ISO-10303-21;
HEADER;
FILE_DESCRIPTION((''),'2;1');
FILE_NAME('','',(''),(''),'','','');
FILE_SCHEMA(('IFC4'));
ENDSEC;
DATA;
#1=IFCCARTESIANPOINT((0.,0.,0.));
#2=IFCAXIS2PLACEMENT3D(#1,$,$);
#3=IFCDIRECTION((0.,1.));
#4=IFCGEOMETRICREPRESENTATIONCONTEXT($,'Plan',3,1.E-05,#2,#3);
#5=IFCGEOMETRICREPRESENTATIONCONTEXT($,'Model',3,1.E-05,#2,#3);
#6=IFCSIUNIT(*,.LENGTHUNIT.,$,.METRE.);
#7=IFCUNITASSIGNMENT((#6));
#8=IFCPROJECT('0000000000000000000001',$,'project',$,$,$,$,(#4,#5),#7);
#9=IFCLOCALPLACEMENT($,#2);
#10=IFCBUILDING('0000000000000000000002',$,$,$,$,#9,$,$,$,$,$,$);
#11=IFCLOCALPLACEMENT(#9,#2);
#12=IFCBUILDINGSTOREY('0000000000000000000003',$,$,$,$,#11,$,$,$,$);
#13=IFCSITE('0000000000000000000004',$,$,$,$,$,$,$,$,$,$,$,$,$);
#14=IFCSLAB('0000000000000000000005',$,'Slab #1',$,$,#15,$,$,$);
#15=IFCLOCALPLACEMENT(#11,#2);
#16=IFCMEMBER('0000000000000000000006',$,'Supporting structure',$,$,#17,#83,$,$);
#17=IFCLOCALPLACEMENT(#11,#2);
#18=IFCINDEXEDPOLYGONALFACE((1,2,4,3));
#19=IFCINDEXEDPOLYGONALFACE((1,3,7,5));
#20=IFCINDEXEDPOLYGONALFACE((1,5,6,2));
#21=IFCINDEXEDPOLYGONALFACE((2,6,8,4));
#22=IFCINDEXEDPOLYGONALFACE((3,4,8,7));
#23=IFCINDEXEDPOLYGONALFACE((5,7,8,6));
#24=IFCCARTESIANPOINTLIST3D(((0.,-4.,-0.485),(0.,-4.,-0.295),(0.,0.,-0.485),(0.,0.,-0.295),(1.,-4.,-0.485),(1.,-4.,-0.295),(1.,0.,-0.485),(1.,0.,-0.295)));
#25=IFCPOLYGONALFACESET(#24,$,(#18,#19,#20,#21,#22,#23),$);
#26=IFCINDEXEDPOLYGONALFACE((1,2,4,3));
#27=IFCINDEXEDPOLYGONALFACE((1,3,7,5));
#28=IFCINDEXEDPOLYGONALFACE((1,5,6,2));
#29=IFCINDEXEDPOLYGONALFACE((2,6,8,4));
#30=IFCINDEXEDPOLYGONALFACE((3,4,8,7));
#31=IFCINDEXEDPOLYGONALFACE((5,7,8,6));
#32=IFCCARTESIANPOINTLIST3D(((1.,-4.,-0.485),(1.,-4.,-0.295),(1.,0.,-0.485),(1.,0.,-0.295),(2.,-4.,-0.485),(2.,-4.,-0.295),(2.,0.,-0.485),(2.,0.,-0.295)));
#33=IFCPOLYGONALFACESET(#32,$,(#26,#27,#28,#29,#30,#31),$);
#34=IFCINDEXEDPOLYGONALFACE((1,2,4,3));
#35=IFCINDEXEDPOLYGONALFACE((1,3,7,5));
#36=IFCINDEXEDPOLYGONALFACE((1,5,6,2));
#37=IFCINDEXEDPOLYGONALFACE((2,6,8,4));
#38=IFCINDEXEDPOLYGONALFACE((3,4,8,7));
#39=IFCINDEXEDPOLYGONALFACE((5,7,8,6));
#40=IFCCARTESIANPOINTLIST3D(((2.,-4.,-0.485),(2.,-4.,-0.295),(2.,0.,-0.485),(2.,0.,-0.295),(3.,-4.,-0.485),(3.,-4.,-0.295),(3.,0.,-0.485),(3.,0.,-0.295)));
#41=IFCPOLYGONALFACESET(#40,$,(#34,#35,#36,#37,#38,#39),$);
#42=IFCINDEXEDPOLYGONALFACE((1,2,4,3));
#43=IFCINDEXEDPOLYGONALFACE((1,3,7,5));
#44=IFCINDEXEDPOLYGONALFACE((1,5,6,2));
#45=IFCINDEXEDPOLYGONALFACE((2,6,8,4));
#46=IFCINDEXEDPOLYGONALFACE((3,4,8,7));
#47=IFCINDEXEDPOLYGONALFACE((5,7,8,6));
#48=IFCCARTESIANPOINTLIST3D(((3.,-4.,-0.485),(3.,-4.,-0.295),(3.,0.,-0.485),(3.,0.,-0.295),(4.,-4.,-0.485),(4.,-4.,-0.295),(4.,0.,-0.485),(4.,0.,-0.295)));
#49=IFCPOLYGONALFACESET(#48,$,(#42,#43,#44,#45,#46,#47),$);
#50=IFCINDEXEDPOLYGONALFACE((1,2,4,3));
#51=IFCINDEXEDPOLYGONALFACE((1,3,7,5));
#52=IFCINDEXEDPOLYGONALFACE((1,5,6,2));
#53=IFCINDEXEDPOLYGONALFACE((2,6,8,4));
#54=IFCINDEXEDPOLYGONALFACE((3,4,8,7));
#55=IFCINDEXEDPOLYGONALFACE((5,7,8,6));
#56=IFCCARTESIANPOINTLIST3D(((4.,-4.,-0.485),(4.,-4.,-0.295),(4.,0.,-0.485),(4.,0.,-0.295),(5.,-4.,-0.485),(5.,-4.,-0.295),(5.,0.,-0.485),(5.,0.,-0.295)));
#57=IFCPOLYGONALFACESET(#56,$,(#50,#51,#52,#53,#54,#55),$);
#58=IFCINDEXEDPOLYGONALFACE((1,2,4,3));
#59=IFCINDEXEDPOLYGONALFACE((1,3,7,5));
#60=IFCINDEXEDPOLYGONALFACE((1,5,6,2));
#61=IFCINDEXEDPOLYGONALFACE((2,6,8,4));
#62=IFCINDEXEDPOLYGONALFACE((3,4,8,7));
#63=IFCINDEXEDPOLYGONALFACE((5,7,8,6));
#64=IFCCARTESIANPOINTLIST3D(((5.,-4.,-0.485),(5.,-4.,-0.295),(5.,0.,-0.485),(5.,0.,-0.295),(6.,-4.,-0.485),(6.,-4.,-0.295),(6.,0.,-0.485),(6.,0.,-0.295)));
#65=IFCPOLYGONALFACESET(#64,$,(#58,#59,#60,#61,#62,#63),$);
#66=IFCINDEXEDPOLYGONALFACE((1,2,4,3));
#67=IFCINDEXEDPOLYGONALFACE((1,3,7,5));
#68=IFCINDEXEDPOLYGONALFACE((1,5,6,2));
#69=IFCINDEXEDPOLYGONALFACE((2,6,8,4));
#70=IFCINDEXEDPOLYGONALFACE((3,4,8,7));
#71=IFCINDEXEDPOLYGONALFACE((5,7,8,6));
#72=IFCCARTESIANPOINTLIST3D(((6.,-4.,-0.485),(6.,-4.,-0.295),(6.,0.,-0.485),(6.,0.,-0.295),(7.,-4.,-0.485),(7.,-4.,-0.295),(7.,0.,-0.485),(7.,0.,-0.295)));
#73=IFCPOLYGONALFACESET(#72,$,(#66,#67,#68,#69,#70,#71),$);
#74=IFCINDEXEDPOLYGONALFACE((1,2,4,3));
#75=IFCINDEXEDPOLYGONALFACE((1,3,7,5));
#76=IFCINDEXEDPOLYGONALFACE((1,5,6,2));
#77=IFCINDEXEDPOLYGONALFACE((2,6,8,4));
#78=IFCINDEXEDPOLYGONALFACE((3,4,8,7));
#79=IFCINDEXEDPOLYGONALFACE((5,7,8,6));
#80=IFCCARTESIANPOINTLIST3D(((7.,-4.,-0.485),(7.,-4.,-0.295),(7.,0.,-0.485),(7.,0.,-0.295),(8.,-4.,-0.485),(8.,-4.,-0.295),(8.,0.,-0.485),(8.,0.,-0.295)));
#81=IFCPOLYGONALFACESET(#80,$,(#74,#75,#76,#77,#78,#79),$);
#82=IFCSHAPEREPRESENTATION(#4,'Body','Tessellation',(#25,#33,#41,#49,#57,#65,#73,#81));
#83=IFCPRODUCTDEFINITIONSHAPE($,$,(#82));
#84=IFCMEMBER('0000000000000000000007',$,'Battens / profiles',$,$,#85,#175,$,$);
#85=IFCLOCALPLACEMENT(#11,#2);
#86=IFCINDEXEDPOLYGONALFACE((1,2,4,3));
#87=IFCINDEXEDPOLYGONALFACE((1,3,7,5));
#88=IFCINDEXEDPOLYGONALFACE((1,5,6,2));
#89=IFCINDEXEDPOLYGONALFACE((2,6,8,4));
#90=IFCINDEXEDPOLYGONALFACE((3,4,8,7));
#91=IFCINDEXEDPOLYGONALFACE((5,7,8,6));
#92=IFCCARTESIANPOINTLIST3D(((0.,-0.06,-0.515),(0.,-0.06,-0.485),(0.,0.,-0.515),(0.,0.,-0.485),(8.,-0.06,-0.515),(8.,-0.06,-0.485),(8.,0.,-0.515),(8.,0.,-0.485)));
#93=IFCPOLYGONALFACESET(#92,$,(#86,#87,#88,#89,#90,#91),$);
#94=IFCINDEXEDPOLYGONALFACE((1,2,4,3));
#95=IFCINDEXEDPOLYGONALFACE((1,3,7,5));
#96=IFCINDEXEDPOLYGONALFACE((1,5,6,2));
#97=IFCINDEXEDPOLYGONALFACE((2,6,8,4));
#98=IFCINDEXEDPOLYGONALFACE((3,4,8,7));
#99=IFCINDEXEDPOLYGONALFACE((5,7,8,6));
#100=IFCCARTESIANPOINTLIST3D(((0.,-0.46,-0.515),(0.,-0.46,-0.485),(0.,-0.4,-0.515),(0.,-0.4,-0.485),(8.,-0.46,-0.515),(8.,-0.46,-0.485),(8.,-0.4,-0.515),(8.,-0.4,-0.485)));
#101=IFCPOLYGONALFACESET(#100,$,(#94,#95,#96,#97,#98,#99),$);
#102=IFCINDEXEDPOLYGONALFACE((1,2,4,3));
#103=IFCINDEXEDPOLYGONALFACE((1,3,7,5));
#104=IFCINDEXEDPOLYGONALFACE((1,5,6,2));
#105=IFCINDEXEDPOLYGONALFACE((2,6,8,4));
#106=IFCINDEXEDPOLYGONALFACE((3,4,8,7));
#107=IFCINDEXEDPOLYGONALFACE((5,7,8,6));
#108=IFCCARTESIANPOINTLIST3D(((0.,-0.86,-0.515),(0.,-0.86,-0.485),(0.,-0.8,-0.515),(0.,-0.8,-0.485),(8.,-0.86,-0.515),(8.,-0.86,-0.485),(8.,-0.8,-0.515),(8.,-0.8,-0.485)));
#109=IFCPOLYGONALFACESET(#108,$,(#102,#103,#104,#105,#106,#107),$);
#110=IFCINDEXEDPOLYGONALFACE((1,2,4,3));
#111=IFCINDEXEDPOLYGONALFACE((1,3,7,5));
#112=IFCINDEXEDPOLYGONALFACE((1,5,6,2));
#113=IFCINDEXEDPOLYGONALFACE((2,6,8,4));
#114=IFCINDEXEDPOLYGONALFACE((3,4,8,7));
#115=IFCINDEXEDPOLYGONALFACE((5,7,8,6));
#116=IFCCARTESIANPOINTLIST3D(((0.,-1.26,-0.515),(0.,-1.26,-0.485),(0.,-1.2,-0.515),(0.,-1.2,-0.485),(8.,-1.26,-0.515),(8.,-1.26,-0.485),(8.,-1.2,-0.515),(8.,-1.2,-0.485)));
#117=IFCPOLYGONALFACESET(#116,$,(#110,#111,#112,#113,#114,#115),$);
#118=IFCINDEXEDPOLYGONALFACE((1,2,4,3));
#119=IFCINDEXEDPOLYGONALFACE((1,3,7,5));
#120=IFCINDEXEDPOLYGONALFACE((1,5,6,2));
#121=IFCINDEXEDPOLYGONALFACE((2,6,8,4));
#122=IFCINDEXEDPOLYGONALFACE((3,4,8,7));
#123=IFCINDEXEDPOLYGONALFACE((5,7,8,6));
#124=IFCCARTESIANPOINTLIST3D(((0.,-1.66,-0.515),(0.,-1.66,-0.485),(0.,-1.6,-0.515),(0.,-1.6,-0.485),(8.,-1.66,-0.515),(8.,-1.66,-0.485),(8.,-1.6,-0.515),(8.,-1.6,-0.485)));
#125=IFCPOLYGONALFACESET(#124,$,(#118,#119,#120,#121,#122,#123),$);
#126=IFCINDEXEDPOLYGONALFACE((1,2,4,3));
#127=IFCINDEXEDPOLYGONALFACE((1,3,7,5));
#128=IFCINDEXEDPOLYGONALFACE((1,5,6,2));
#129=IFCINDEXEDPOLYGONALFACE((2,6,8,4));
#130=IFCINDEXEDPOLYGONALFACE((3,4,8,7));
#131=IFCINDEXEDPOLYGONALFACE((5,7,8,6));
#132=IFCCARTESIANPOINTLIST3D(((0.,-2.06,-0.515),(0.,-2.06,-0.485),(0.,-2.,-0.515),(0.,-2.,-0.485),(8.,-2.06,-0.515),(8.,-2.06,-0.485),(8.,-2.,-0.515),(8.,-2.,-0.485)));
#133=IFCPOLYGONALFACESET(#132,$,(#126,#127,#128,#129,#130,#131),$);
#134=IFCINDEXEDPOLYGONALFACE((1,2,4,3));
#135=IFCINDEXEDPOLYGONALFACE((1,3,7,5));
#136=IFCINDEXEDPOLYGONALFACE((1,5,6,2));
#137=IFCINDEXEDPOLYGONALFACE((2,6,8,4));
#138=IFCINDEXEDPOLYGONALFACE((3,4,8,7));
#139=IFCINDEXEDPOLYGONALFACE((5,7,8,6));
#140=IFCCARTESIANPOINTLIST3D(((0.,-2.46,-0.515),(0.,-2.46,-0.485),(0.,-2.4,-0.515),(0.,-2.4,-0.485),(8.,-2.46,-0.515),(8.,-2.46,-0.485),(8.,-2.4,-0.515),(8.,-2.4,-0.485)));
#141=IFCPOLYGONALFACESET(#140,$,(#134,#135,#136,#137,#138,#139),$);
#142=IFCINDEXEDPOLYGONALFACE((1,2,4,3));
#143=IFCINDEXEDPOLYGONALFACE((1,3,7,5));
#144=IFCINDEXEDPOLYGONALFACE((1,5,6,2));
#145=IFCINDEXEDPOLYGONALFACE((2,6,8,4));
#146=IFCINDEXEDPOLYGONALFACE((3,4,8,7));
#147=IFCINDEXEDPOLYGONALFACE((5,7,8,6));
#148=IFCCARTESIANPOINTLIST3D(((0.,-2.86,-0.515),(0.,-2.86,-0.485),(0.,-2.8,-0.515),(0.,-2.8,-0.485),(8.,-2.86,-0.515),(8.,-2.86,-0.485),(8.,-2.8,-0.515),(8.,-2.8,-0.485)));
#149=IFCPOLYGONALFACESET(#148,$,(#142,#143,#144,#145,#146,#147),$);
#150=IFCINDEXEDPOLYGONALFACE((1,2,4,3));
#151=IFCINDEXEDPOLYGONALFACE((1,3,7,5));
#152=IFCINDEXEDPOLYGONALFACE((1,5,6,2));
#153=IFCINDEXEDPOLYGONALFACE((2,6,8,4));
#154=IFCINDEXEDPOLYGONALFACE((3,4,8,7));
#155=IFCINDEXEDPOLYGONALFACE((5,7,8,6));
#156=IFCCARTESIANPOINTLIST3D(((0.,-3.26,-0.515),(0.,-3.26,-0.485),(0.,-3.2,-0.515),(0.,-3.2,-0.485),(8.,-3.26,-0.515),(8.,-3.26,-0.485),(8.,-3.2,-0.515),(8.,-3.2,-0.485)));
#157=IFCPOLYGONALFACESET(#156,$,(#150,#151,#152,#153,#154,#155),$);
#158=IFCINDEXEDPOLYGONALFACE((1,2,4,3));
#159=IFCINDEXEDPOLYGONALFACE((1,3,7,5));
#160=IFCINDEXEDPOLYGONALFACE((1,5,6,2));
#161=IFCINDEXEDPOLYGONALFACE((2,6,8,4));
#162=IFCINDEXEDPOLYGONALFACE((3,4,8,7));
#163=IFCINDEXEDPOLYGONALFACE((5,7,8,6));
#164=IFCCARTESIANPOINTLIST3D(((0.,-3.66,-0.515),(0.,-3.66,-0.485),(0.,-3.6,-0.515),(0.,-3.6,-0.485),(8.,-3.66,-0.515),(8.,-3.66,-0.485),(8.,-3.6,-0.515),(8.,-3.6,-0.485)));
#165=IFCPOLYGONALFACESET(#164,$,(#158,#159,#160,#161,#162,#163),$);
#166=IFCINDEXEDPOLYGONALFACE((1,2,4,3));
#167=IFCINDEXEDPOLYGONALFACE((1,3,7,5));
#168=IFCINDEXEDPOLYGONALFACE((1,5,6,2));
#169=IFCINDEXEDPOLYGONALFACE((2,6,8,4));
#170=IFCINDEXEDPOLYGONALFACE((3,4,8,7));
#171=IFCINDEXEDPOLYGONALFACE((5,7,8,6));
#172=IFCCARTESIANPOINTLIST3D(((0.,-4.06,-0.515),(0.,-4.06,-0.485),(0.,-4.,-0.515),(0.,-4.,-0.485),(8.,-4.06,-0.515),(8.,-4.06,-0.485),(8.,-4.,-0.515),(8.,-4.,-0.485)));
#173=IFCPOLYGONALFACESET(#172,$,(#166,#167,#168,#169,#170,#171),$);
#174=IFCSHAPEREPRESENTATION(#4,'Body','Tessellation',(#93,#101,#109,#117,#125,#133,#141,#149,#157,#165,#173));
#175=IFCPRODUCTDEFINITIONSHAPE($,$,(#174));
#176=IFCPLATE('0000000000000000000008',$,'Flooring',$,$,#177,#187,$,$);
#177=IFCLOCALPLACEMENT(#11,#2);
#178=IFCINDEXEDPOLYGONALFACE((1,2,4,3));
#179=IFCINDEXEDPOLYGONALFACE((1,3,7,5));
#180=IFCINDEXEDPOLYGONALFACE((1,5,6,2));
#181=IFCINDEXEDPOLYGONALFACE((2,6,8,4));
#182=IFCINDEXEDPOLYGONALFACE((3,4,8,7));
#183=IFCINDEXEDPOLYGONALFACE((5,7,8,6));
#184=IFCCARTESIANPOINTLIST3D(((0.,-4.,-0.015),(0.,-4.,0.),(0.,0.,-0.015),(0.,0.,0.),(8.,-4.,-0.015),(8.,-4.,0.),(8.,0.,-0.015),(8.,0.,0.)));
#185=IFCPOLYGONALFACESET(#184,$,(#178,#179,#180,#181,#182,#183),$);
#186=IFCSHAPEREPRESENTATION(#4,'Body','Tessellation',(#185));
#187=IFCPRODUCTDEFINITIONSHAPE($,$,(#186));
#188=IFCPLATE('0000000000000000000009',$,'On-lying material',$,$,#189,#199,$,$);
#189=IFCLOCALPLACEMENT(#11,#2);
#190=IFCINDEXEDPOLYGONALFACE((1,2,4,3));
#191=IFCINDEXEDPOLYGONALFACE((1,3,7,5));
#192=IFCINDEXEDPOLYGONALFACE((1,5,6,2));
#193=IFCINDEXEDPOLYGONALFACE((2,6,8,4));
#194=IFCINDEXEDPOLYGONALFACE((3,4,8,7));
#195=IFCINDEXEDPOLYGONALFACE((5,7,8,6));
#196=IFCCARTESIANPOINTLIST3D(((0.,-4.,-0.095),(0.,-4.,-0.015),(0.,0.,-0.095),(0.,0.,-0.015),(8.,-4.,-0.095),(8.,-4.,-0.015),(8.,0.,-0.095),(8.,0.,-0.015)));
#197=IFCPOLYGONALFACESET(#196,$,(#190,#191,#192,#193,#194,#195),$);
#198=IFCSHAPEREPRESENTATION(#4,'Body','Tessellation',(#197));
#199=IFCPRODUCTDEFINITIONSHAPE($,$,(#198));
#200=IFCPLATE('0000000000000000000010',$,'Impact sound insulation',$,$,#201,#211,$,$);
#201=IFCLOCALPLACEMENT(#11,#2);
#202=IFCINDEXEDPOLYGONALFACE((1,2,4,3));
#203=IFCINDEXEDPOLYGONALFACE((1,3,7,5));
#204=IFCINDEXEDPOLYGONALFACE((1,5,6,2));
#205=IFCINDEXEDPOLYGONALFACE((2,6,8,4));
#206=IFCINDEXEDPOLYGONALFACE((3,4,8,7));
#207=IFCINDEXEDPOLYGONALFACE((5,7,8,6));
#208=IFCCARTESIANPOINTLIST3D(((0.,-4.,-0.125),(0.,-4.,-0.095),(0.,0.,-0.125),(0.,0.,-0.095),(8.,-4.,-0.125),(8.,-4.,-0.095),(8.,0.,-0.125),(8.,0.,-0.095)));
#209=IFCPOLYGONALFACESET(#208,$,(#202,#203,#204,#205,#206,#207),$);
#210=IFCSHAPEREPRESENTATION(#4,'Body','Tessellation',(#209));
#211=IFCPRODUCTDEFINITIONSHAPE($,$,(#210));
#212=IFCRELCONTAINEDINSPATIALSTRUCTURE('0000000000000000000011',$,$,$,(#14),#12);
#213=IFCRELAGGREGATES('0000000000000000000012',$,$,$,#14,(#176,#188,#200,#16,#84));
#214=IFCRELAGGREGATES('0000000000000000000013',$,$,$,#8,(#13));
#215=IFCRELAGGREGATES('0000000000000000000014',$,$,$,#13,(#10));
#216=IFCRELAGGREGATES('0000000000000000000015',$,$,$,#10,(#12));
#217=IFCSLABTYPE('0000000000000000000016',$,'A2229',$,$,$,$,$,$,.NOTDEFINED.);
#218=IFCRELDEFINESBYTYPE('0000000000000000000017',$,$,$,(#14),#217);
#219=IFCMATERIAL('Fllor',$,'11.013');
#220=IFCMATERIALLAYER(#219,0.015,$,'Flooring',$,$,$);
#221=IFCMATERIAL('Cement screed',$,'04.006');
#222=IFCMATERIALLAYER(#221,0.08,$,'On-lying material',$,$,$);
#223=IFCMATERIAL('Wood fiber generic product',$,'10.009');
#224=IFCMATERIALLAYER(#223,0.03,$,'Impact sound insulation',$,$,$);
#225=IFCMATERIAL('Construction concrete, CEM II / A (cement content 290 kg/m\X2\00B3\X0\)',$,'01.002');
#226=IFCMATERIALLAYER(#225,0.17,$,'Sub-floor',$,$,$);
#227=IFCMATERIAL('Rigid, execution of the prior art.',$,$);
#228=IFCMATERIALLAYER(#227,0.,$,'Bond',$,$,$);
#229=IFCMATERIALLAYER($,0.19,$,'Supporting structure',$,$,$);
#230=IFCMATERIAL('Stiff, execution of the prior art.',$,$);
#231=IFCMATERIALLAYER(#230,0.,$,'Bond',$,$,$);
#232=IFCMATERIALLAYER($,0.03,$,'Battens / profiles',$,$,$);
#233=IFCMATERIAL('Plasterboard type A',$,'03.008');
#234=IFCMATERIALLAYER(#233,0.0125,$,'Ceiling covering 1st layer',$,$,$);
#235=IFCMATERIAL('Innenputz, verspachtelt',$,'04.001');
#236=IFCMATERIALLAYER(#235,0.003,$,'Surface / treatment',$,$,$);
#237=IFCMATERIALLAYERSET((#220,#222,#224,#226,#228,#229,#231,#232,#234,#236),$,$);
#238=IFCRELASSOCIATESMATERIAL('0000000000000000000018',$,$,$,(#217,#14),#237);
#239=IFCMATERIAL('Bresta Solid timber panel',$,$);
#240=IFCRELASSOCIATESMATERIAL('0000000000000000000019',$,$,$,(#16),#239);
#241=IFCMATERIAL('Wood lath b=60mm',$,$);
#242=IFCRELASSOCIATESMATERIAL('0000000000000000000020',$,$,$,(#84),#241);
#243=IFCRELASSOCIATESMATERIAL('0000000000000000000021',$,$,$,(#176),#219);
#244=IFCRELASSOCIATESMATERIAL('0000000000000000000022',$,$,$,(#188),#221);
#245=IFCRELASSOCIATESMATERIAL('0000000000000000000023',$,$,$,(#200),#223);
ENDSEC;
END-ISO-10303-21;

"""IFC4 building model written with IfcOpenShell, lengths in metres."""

from ifc_helpers import new_model, si_unit, direction, frame, frame_2d, origin, origin_with_axes, place, context, project, spatial, rectangle, extrude, material, layer, layer_set, type_object, element, aggregate, save


model = new_model("IFC4")

# Units and contexts
plan_context = context("Plan", 3, precision=1e-05, world=origin(), true_north=direction((0.0, 1.0)))
model_context = context("Model", 3, precision=1e-05, world=origin(), true_north=direction((0.0, 1.0)))
ifc_project = project(units=[si_unit("LENGTHUNIT", "METRE")], contexts=[plan_context, model_context])

# Site, building, storey
site = spatial("IfcSite", under=ifc_project)
building_placement = place(None, origin())
building = spatial("IfcBuilding", under=site, at=building_placement)
storey_placement = place(building_placement, origin())
storey = spatial("IfcBuildingStorey", under=building, at=storey_placement)

# Slab, members, plates
ifc_material_1 = material(Name="Fllor", Category="11.013")
ifc_layer_1 = layer(ifc_material_1, 0.015, Name="Flooring")
ifc_material_2 = material(Name="Cement screed", Category="04.006")
ifc_layer_2 = layer(ifc_material_2, 0.08, Name="On-lying material")
ifc_material_3 = material(Name="Wood fiber generic product", Category="10.009")
ifc_layer_3 = layer(ifc_material_3, 0.03, Name="Impact sound insulation")
ifc_material_4 = material(Name="Construction concrete, CEM II / A (cement content 290 kg/m³)", Category="01.002")
ifc_layer_4 = layer(ifc_material_4, 0.17, Name="Sub-floor")
ifc_material_5 = material(Name="Rigid, execution of the prior art.")
ifc_layer_5 = layer(ifc_material_5, 0.0, Name="Bond")
ifc_layer_6 = layer(None, 0.19, Name="Supporting structure")
ifc_material_6 = material(Name="Stiff, execution of the prior art.")
ifc_layer_7 = layer(ifc_material_6, 0.0, Name="Bond")
ifc_layer_8 = layer(None, 0.03, Name="Battens / profiles")
ifc_material_7 = material(Name="Plasterboard type A", Category="03.008")
ifc_layer_9 = layer(ifc_material_7, 0.0125, Name="Ceiling covering 1st layer")
ifc_material_8 = material(Name="Innenputz, verspachtelt", Category="04.001")
ifc_layer_10 = layer(ifc_material_8, 0.003, Name="Surface / treatment")
ifc_layer_set = layer_set([ifc_layer_1, ifc_layer_2, ifc_layer_3, ifc_layer_4, ifc_layer_5, ifc_layer_6, ifc_layer_7, ifc_layer_8, ifc_layer_9, ifc_layer_10])
slab_type = type_object("IfcSlabType", Name="A2229", PredefinedType="NOTDEFINED", material=ifc_layer_set)
slab_placement = place(None, frame((0.0, 0.0, 0.0), z_axis=(0.0, 0.0, -1.0), x_axis=(1.0, 0.0, 0.0)))
slab = element("IfcSlab", 1, at=slab_placement, inside=storey, type_object=slab_type, material=ifc_layer_set, Name="Slab #1")
ifc_material_9 = material(Name="Bresta Solid timber panel")
member_1_placement = place(slab_placement, origin())
member_1 = element("IfcMember", 2, at=member_1_placement, material=ifc_material_9, Name="Supporting structure", context=plan_context, shape_type="SweptSolid", body=[
    extrude(rectangle(XDim=1.0, YDim=0.19, at=frame_2d((0.5, 0.095), x_axis=(1.0, 0.0))), frame((0.0, 4.0, 0.295), z_axis=(0.0, -1.0, 0.0), x_axis=(1.0, 0.0, 0.0)), (0.0, 0.0, 1.0), 4.0),
    extrude(rectangle(XDim=1.0, YDim=0.19, at=frame_2d((0.5, 0.095), x_axis=(1.0, 0.0))), frame((1.0, 4.0, 0.295), z_axis=(0.0, -1.0, 0.0), x_axis=(1.0, 0.0, 0.0)), (0.0, 0.0, 1.0), 4.0),
    extrude(rectangle(XDim=1.0, YDim=0.19, at=frame_2d((0.5, 0.095), x_axis=(1.0, 0.0))), frame((2.0, 4.0, 0.295), z_axis=(0.0, -1.0, 0.0), x_axis=(1.0, 0.0, 0.0)), (0.0, 0.0, 1.0), 4.0),
    extrude(rectangle(XDim=1.0, YDim=0.19, at=frame_2d((0.5, 0.095), x_axis=(1.0, 0.0))), frame((3.0, 4.0, 0.295), z_axis=(0.0, -1.0, 0.0), x_axis=(1.0, 0.0, 0.0)), (0.0, 0.0, 1.0), 4.0),
    extrude(rectangle(XDim=1.0, YDim=0.19, at=frame_2d((0.5, 0.095), x_axis=(1.0, 0.0))), frame((4.0, 4.0, 0.295), z_axis=(0.0, -1.0, 0.0), x_axis=(1.0, 0.0, 0.0)), (0.0, 0.0, 1.0), 4.0),
    extrude(rectangle(XDim=1.0, YDim=0.19, at=frame_2d((0.5, 0.095), x_axis=(1.0, 0.0))), frame((5.0, 4.0, 0.295), z_axis=(0.0, -1.0, 0.0), x_axis=(1.0, 0.0, 0.0)), (0.0, 0.0, 1.0), 4.0),
    extrude(rectangle(XDim=1.0, YDim=0.19, at=frame_2d((0.5, 0.095), x_axis=(1.0, 0.0))), frame((6.0, 4.0, 0.295), z_axis=(0.0, -1.0, 0.0), x_axis=(1.0, 0.0, 0.0)), (0.0, 0.0, 1.0), 4.0),
    extrude(rectangle(XDim=1.0, YDim=0.19, at=frame_2d((0.5, 0.095), x_axis=(1.0, 0.0))), frame((7.0, 4.0, 0.295), z_axis=(0.0, -1.0, 0.0), x_axis=(1.0, 0.0, 0.0)), (0.0, 0.0, 1.0), 4.0),
])
ifc_material_10 = material(Name="Wood lath b=60mm")
member_2_placement = place(slab_placement, origin())
member_2 = element("IfcMember", 3, at=member_2_placement, material=ifc_material_10, Name="Battens / profiles", context=plan_context, shape_type="SweptSolid", body=[
    extrude(rectangle(XDim=0.06, YDim=0.03, at=frame_2d((0.03, 0.015), x_axis=(1.0, 0.0))), frame((0.0, 0.0, 0.485), z_axis=(1.0, 0.0, 0.0), x_axis=(0.0, 1.0, 0.0)), (0.0, 0.0, 1.0), 8.0),
    extrude(rectangle(XDim=0.06, YDim=0.03, at=frame_2d((0.03, 0.015), x_axis=(1.0, 0.0))), frame((0.0, 0.4, 0.485), z_axis=(1.0, 0.0, 0.0), x_axis=(0.0, 1.0, 0.0)), (0.0, 0.0, 1.0), 8.0),
    extrude(rectangle(XDim=0.06, YDim=0.03, at=frame_2d((0.03, 0.015), x_axis=(1.0, 0.0))), frame((0.0, 0.8, 0.485), z_axis=(1.0, 0.0, 0.0), x_axis=(0.0, 1.0, 0.0)), (0.0, 0.0, 1.0), 8.0),
    extrude(rectangle(XDim=0.06, YDim=0.03, at=frame_2d((0.03, 0.015), x_axis=(1.0, 0.0))), frame((0.0, 1.2, 0.485), z_axis=(1.0, 0.0, 0.0), x_axis=(0.0, 1.0, 0.0)), (0.0, 0.0, 1.0), 8.0),
    extrude(rectangle(XDim=0.06, YDim=0.03, at=frame_2d((0.03, 0.015), x_axis=(1.0, 0.0))), frame((0.0, 1.6, 0.485), z_axis=(1.0, 0.0, 0.0), x_axis=(0.0, 1.0, 0.0)), (0.0, 0.0, 1.0), 8.0),
    extrude(rectangle(XDim=0.06, YDim=0.03, at=frame_2d((0.03, 0.015), x_axis=(1.0, 0.0))), frame((0.0, 2.0, 0.485), z_axis=(1.0, 0.0, 0.0), x_axis=(0.0, 1.0, 0.0)), (0.0, 0.0, 1.0), 8.0),
    extrude(rectangle(XDim=0.06, YDim=0.03, at=frame_2d((0.03, 0.015), x_axis=(1.0, 0.0))), frame((0.0, 2.4, 0.485), z_axis=(1.0, 0.0, 0.0), x_axis=(0.0, 1.0, 0.0)), (0.0, 0.0, 1.0), 8.0),
    extrude(rectangle(XDim=0.06, YDim=0.03, at=frame_2d((0.03, 0.015), x_axis=(1.0, 0.0))), frame((0.0, 2.8, 0.485), z_axis=(1.0, 0.0, 0.0), x_axis=(0.0, 1.0, 0.0)), (0.0, 0.0, 1.0), 8.0),
    extrude(rectangle(XDim=0.06, YDim=0.03, at=frame_2d((0.03, 0.015), x_axis=(1.0, 0.0))), frame((0.0, 3.2, 0.485), z_axis=(1.0, 0.0, 0.0), x_axis=(0.0, 1.0, 0.0)), (0.0, 0.0, 1.0), 8.0),
    extrude(rectangle(XDim=0.06, YDim=0.03, at=frame_2d((0.03, 0.015), x_axis=(1.0, 0.0))), frame((0.0, 3.6, 0.485), z_axis=(1.0, 0.0, 0.0), x_axis=(0.0, 1.0, 0.0)), (0.0, 0.0, 1.0), 8.0),
    extrude(rectangle(XDim=0.06, YDim=0.03, at=frame_2d((0.03, 0.015), x_axis=(1.0, 0.0))), frame((0.0, 4.0, 0.485), z_axis=(1.0, 0.0, 0.0), x_axis=(0.0, 1.0, 0.0)), (0.0, 0.0, 1.0), 8.0),
])
plate_1_placement = place(slab_placement, origin())
plate_1 = element("IfcPlate", 4, at=plate_1_placement, material=ifc_material_1, Name="Flooring", context=plan_context, shape_type="SweptSolid", body=[
    extrude(rectangle(XDim=8.0, YDim=4.0, at=frame_2d((4.0, 2.0), x_axis=(1.0, 0.0))), origin_with_axes(), (0.0, 0.0, 1.0), 0.015),
])
plate_2_placement = place(slab_placement, origin())
plate_2 = element("IfcPlate", 5, at=plate_2_placement, material=ifc_material_2, Name="On-lying material", context=plan_context, shape_type="SweptSolid", body=[
    extrude(rectangle(XDim=8.0, YDim=4.0, at=frame_2d((4.0, 2.0), x_axis=(1.0, 0.0))), frame((0.0, 0.0, 0.015), z_axis=(0.0, 0.0, 1.0), x_axis=(1.0, 0.0, 0.0)), (0.0, 0.0, 1.0), 0.08),
])
plate_3_placement = place(slab_placement, origin())
plate_3 = element("IfcPlate", 6, at=plate_3_placement, material=ifc_material_3, Name="Impact sound insulation", context=plan_context, shape_type="SweptSolid", body=[
    extrude(rectangle(XDim=8.0, YDim=4.0, at=frame_2d((4.0, 2.0), x_axis=(1.0, 0.0))), frame((0.0, 0.0, 0.095), z_axis=(0.0, 0.0, 1.0), x_axis=(1.0, 0.0, 0.0)), (0.0, 0.0, 1.0), 0.03),
])
aggregate(slab, [plate_1, plate_2, plate_3, member_1, member_2])

save(model, "model.ifc")
